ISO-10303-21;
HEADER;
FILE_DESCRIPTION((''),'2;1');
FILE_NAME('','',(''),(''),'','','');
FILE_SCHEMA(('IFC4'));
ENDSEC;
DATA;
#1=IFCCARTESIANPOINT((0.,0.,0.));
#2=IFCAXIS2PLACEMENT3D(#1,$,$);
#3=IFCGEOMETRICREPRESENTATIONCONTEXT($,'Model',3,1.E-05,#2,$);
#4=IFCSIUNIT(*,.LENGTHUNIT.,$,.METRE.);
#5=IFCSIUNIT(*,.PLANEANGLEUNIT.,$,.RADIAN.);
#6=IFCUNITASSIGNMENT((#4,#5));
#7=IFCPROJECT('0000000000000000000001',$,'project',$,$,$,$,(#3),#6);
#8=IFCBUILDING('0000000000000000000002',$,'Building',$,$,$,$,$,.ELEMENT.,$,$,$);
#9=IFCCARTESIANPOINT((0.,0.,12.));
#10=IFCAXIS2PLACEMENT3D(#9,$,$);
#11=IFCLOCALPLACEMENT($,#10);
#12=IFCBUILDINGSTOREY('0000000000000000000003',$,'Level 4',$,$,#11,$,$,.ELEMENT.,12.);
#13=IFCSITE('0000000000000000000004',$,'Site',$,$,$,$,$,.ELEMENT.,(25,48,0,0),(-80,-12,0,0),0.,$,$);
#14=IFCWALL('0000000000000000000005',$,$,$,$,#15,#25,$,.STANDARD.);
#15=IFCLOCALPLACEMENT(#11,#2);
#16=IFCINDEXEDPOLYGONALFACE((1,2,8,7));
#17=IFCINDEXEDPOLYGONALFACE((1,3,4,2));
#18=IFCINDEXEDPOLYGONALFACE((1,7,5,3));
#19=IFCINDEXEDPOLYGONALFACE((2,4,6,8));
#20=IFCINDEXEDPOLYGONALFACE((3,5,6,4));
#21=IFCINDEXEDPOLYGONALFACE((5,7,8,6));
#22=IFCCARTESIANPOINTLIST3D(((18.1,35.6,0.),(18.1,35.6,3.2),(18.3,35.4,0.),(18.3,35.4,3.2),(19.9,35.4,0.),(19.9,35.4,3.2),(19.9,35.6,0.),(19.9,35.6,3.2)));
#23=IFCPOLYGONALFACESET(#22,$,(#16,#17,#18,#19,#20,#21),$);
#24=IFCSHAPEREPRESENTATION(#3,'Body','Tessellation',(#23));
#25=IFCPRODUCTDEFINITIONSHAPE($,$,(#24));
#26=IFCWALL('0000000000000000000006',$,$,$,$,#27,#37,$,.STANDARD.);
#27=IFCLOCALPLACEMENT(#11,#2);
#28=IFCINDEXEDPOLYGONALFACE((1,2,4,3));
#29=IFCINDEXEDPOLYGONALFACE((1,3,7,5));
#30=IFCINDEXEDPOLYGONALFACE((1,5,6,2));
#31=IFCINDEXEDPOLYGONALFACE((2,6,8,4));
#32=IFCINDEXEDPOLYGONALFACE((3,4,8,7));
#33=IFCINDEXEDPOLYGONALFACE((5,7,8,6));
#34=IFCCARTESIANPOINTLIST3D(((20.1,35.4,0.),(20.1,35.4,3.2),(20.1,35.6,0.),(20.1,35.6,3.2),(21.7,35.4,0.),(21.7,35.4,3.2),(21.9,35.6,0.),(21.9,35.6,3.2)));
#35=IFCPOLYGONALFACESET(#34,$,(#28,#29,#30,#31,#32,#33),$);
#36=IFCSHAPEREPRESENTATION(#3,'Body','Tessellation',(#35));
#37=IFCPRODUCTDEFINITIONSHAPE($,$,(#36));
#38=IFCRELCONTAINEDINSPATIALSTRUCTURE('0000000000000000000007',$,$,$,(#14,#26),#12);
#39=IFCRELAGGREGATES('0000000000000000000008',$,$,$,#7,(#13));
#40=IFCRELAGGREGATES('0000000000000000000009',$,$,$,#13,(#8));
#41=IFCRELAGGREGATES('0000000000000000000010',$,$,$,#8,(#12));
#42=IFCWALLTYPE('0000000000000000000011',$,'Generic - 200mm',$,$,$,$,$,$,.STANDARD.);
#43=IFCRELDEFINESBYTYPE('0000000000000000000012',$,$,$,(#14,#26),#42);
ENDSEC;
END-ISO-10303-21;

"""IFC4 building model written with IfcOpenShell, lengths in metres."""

from ifc_helpers import new_model, si_unit, frame, origin, place, context, project, spatial, polyline, outline, extrude, type_object, element, save


model = new_model("IFC4")

# Units and contexts
model_context = context("Model", 3, precision=1e-05, world=origin())
ifc_project = project(units=[si_unit("LENGTHUNIT", "METRE"), si_unit("PLANEANGLEUNIT", "RADIAN")], contexts=[model_context])

# Site, building, storey
site = spatial("IfcSite", under=ifc_project, Name="Site", CompositionType="ELEMENT", RefLatitude=(25, 48, 0, 0), RefLongitude=(-80, -12, 0, 0), RefElevation=0.0)
building = spatial("IfcBuilding", under=site, Name="Building", CompositionType="ELEMENT")
storey_placement = place(None, frame((0.0, 0.0, 12.0)))
storey = spatial("IfcBuildingStorey", under=building, at=storey_placement, Name="Level 4", CompositionType="ELEMENT", Elevation=12.0)

# Shared definitions
wall_type = type_object("IfcWallType", Name="Generic - 200mm", PredefinedType="STANDARD")

# Walls
wall_1_placement = place(None, frame((18.2, 35.5, 12.0), z_axis=(0.0, 0.0, 1.0), x_axis=(1.0, 0.0, 0.0)))
element("IfcWall", 1, at=wall_1_placement, inside=storey, type_object=wall_type, PredefinedType="STANDARD", context=model_context, shape_type="SweptSolid", body=[
    extrude(outline(polyline([(0.1, -0.1), (1.7, -0.1), (1.7, 0.1), (-0.1, 0.1), (0.1, -0.1)])), origin(), (0.0, 0.0, 1.0), 3.2),
])
wall_2_placement = place(None, frame((21.8, 35.5, 12.0), z_axis=(0.0, 0.0, 1.0), x_axis=(-1.0, 0.0, 0.0)))
element("IfcWall", 2, at=wall_2_placement, inside=storey, type_object=wall_type, PredefinedType="STANDARD", context=model_context, shape_type="SweptSolid", body=[
    extrude(outline(polyline([(-0.1, -0.1), (1.7, -0.1), (1.7, 0.1), (0.1, 0.1), (-0.1, -0.1)])), origin(), (0.0, 0.0, 1.0), 3.2),
])

save(model, "model.ifc")
